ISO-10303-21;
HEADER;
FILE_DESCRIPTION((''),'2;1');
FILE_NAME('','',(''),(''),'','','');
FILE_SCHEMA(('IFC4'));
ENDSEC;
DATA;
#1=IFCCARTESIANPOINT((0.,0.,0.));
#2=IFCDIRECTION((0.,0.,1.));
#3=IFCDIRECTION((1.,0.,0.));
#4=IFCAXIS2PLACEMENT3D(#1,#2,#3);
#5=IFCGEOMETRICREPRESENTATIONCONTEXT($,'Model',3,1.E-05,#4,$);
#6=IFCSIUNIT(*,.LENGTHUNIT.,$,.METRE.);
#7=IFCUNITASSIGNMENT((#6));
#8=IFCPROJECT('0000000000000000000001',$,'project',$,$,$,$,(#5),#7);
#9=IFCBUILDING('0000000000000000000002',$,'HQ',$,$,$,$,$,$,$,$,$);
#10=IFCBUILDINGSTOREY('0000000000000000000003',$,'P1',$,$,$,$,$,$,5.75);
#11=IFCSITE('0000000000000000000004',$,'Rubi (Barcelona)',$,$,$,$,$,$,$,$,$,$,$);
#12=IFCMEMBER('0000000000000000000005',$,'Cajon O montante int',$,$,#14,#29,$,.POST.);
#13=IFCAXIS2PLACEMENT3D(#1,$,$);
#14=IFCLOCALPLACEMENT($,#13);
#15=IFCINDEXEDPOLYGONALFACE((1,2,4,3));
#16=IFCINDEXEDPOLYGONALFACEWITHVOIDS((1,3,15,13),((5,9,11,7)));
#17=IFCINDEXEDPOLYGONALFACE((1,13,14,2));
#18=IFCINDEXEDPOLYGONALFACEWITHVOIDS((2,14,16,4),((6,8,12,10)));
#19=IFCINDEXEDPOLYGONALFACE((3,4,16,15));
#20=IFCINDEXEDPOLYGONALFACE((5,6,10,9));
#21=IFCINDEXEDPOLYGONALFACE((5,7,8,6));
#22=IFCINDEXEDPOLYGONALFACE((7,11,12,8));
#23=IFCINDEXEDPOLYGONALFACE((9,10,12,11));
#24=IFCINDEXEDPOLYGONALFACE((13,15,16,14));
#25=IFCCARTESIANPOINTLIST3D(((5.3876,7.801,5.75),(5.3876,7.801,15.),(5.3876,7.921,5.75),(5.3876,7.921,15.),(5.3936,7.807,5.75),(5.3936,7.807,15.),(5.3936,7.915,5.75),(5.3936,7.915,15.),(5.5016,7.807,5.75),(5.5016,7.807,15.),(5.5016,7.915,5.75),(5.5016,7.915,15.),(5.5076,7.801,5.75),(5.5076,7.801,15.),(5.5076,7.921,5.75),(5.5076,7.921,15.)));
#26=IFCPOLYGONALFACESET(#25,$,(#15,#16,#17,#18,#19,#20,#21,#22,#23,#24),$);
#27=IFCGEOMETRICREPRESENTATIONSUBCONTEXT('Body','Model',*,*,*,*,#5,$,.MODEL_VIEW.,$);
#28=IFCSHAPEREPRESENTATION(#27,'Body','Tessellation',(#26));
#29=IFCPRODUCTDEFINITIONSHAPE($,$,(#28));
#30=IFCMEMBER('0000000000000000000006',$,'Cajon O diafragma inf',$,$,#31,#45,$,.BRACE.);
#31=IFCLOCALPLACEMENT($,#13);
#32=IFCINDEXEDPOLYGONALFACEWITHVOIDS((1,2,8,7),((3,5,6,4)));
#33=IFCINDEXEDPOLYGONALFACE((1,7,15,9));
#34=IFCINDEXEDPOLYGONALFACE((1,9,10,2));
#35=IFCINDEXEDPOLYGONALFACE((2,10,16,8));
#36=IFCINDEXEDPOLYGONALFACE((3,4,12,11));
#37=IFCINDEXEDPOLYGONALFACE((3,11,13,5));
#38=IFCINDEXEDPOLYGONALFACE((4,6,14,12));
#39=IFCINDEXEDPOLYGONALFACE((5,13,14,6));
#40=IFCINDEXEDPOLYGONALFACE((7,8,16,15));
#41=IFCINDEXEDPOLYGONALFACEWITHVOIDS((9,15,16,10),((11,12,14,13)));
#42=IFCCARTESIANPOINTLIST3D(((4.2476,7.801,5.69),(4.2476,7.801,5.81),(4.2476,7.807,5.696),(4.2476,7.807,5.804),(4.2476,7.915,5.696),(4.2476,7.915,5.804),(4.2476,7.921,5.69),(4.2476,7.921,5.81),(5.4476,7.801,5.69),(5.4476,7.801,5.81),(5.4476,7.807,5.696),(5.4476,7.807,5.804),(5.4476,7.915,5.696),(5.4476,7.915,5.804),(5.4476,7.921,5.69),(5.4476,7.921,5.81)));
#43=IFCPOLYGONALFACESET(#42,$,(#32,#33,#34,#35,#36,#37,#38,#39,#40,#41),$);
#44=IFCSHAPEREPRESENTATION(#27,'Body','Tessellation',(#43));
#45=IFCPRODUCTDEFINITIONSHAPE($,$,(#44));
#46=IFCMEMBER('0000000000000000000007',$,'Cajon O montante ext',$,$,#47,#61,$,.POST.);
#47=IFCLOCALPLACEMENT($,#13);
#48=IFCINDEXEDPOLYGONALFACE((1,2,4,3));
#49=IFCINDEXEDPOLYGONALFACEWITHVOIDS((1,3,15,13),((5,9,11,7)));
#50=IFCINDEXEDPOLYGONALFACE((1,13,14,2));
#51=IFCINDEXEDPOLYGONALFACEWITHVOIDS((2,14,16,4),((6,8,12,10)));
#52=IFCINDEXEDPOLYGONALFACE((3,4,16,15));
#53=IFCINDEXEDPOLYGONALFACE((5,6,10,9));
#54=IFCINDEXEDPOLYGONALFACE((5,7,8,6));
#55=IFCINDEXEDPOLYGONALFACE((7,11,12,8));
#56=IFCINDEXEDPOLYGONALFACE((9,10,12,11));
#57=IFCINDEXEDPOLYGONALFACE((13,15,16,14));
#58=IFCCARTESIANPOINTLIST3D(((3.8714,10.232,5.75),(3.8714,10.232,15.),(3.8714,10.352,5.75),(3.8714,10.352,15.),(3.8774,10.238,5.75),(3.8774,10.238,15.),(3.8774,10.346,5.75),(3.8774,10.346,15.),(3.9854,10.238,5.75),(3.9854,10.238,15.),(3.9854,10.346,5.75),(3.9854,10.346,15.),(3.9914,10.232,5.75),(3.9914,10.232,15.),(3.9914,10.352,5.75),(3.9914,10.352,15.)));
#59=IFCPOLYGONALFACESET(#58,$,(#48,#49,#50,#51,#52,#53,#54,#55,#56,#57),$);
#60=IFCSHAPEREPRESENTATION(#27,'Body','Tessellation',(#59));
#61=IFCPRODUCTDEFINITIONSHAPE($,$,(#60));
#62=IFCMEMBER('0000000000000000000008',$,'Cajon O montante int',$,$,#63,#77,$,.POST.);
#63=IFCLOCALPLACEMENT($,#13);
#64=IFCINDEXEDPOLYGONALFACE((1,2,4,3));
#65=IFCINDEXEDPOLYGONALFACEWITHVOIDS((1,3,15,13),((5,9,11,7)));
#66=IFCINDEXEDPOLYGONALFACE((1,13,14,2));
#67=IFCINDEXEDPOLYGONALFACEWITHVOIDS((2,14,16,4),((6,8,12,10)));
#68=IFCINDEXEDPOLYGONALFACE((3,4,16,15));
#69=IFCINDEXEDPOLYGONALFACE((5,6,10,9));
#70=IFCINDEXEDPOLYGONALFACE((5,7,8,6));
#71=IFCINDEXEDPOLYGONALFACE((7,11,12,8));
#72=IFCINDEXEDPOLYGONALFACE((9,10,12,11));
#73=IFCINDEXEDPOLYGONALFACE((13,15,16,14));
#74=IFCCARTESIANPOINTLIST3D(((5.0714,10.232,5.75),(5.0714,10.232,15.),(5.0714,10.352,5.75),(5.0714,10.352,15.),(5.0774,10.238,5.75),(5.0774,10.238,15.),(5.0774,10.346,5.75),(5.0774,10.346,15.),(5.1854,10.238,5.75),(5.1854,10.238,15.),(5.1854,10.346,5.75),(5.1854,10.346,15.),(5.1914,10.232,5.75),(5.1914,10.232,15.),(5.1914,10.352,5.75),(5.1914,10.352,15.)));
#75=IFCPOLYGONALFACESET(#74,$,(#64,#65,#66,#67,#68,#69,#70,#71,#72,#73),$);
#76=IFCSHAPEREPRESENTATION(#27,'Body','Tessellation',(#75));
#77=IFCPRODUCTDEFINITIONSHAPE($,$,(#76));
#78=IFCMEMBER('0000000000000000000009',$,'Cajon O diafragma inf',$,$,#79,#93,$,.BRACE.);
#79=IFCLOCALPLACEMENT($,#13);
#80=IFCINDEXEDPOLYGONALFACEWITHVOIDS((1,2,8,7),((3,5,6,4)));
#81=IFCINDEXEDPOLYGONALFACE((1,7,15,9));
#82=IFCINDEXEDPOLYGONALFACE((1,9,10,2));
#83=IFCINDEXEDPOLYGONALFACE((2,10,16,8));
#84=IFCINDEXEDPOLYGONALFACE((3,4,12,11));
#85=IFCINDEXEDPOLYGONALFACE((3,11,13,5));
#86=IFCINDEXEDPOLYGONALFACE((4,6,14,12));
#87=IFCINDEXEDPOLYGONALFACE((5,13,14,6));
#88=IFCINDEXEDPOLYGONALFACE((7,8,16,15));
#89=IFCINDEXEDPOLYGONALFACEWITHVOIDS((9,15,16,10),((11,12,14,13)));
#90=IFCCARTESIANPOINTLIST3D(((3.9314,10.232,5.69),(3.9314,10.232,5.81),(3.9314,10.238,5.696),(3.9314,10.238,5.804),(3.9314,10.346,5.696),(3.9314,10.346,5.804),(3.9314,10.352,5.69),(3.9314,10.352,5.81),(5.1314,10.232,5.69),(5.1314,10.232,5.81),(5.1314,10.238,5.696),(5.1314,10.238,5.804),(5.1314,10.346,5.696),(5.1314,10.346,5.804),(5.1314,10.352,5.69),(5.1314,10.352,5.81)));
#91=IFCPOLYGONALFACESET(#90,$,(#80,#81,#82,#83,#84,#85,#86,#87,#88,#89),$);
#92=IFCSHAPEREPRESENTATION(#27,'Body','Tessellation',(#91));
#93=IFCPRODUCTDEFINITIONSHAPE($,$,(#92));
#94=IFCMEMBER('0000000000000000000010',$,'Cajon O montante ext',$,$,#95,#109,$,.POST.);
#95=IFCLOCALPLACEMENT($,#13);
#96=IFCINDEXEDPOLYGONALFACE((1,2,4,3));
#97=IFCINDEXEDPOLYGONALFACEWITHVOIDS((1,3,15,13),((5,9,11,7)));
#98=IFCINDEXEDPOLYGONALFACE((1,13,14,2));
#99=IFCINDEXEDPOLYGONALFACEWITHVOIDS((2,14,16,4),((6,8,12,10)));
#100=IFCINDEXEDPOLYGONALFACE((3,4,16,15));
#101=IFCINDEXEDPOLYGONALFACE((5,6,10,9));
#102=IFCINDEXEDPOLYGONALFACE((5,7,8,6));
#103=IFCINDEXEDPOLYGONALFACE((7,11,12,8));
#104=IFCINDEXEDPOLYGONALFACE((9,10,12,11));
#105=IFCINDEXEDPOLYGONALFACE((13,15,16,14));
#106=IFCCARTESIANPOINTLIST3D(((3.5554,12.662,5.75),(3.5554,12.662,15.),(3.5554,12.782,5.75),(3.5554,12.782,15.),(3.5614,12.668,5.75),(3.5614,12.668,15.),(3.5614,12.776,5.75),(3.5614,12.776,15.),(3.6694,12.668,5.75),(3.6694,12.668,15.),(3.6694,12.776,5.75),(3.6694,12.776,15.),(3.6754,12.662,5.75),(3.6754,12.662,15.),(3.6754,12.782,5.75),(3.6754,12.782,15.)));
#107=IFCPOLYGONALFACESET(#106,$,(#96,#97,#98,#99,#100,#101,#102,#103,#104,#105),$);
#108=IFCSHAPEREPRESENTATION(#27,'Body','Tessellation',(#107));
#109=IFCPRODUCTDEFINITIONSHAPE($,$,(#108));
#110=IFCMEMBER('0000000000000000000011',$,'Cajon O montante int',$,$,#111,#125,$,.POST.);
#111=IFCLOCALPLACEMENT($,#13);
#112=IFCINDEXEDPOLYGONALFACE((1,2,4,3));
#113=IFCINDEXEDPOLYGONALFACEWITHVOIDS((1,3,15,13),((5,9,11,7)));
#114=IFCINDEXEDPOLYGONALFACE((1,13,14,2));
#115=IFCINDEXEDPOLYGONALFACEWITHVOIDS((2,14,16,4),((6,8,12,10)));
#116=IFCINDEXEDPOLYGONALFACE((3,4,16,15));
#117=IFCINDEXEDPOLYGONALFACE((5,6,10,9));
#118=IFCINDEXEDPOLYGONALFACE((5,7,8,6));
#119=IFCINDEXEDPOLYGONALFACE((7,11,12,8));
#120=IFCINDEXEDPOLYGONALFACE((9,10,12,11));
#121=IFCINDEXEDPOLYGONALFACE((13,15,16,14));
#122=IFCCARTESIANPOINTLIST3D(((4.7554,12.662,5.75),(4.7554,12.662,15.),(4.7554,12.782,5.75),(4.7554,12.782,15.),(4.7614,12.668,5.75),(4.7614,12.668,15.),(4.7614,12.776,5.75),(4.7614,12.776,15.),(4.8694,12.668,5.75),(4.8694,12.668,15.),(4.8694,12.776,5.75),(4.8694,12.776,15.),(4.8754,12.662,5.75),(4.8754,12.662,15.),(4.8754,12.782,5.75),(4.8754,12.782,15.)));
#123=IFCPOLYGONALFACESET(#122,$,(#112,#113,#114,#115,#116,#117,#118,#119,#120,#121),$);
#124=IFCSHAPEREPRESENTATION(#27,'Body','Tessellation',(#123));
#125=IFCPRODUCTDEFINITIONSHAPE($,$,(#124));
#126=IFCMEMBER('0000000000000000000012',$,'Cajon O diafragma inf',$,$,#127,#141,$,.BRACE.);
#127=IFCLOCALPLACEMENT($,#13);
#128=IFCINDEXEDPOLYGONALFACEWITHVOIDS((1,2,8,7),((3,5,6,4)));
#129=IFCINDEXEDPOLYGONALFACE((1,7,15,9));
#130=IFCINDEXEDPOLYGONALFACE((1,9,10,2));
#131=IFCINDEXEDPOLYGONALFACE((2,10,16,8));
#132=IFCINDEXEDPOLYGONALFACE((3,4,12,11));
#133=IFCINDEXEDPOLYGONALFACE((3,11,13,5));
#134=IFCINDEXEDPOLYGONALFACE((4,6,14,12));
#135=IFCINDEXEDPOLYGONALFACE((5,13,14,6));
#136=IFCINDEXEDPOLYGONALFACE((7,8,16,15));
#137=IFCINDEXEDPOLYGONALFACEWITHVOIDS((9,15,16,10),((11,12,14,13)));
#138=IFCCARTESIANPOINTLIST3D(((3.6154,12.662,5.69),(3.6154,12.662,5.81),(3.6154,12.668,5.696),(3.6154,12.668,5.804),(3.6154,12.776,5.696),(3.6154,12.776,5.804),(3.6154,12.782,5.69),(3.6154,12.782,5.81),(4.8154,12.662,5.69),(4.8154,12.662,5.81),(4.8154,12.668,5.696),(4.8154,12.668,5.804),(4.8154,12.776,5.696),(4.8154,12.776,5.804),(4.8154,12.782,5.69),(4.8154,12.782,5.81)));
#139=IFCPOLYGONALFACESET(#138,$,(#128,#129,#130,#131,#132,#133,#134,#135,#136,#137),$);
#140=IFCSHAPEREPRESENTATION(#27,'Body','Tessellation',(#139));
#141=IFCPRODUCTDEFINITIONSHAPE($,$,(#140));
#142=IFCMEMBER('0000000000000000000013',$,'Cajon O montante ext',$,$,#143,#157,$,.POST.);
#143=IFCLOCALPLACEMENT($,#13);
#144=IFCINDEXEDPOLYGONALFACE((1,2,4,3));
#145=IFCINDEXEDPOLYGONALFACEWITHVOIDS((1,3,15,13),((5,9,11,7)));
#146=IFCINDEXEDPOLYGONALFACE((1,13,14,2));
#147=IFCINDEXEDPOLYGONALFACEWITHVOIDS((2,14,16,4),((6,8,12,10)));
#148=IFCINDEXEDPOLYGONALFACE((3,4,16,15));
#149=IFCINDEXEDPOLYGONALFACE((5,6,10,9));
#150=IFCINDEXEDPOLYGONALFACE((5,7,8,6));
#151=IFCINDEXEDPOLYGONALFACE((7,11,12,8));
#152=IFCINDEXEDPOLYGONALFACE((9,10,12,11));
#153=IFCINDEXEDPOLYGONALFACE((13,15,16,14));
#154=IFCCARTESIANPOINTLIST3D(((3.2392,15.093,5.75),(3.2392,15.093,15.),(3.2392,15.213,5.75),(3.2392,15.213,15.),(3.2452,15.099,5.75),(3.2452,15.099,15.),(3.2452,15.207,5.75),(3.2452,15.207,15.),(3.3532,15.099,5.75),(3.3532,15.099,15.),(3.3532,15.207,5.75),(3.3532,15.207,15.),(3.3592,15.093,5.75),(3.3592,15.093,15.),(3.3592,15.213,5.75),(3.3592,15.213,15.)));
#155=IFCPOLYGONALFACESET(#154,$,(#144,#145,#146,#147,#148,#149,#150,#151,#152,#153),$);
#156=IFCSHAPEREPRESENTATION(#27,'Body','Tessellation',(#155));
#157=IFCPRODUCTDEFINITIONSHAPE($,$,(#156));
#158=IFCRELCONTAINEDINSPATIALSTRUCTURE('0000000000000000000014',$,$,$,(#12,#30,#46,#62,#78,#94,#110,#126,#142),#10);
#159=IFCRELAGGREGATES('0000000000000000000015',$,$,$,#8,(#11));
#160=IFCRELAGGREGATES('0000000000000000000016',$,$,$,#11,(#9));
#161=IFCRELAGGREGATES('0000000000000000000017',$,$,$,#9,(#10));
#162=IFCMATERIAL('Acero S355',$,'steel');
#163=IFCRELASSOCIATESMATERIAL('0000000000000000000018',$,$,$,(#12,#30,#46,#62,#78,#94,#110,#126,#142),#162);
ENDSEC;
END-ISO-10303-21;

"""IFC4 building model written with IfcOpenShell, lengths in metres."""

from ifc_helpers import new_model, si_unit, frame, origin_with_axes, place, context, subcontext, project, spatial, hollow_rectangle, extrude, material, element, save


model = new_model("IFC4")

# Units and contexts
model_context = context("Model", 3, precision=1e-05, world=origin_with_axes())
body_context = subcontext(model_context, "Body", "Model", "MODEL_VIEW")
ifc_project = project(units=[si_unit("LENGTHUNIT", "METRE")], contexts=[model_context])

# Site, building, storey
site = spatial("IfcSite", under=ifc_project, Name="Rubi (Barcelona)")
building = spatial("IfcBuilding", under=site, Name="HQ")
storey = spatial("IfcBuildingStorey", under=building, Name="P1", Elevation=5.75)

# Members
ifc_material = material(Name="Acero S355", Category="steel")
member_1_placement = place(None, origin_with_axes())
element("IfcMember", 1, at=member_1_placement, inside=storey, material=ifc_material, Name="Cajon O montante int", PredefinedType="POST", context=body_context, shape_type="SweptSolid", body=[
    extrude(hollow_rectangle(XDim=0.12, YDim=0.12, WallThickness=0.006), frame((5.4476, 7.861, 5.75), z_axis=(0.0, 0.0, 1.0), x_axis=(1.0, 0.0, 0.0)), (0.0, 0.0, 1.0), 9.25),
])
member_2_placement = place(None, origin_with_axes())
element("IfcMember", 2, at=member_2_placement, inside=storey, material=ifc_material, Name="Cajon O diafragma inf", PredefinedType="BRACE", context=body_context, shape_type="SweptSolid", body=[
    extrude(hollow_rectangle(XDim=0.12, YDim=0.12, WallThickness=0.006), frame((4.2476, 7.861, 5.75), z_axis=(1.0, 0.0, 0.0), x_axis=(0.0, 1.0, 0.0)), (0.0, 0.0, 1.0), 1.2),
])
member_3_placement = place(None, origin_with_axes())
element("IfcMember", 3, at=member_3_placement, inside=storey, material=ifc_material, Name="Cajon O montante ext", PredefinedType="POST", context=body_context, shape_type="SweptSolid", body=[
    extrude(hollow_rectangle(XDim=0.12, YDim=0.12, WallThickness=0.006), frame((3.9314, 10.292, 5.75), z_axis=(0.0, 0.0, 1.0), x_axis=(1.0, 0.0, 0.0)), (0.0, 0.0, 1.0), 9.25),
])
member_4_placement = place(None, origin_with_axes())
element("IfcMember", 4, at=member_4_placement, inside=storey, material=ifc_material, Name="Cajon O montante int", PredefinedType="POST", context=body_context, shape_type="SweptSolid", body=[
    extrude(hollow_rectangle(XDim=0.12, YDim=0.12, WallThickness=0.006), frame((5.1314, 10.292, 5.75), z_axis=(0.0, 0.0, 1.0), x_axis=(1.0, 0.0, 0.0)), (0.0, 0.0, 1.0), 9.25),
])
member_5_placement = place(None, origin_with_axes())
element("IfcMember", 5, at=member_5_placement, inside=storey, material=ifc_material, Name="Cajon O diafragma inf", PredefinedType="BRACE", context=body_context, shape_type="SweptSolid", body=[
    extrude(hollow_rectangle(XDim=0.12, YDim=0.12, WallThickness=0.006), frame((3.9314, 10.292, 5.75), z_axis=(1.0, 0.0, 0.0), x_axis=(0.0, 1.0, 0.0)), (0.0, 0.0, 1.0), 1.2),
])
member_6_placement = place(None, origin_with_axes())
element("IfcMember", 6, at=member_6_placement, inside=storey, material=ifc_material, Name="Cajon O montante ext", PredefinedType="POST", context=body_context, shape_type="SweptSolid", body=[
    extrude(hollow_rectangle(XDim=0.12, YDim=0.12, WallThickness=0.006), frame((3.6154, 12.722, 5.75), z_axis=(0.0, 0.0, 1.0), x_axis=(1.0, 0.0, 0.0)), (0.0, 0.0, 1.0), 9.25),
])
member_7_placement = place(None, origin_with_axes())
element("IfcMember", 7, at=member_7_placement, inside=storey, material=ifc_material, Name="Cajon O montante int", PredefinedType="POST", context=body_context, shape_type="SweptSolid", body=[
    extrude(hollow_rectangle(XDim=0.12, YDim=0.12, WallThickness=0.006), frame((4.8154, 12.722, 5.75), z_axis=(0.0, 0.0, 1.0), x_axis=(1.0, 0.0, 0.0)), (0.0, 0.0, 1.0), 9.25),
])
member_8_placement = place(None, origin_with_axes())
element("IfcMember", 8, at=member_8_placement, inside=storey, material=ifc_material, Name="Cajon O diafragma inf", PredefinedType="BRACE", context=body_context, shape_type="SweptSolid", body=[
    extrude(hollow_rectangle(XDim=0.12, YDim=0.12, WallThickness=0.006), frame((3.6154, 12.722, 5.75), z_axis=(1.0, 0.0, 0.0), x_axis=(0.0, 1.0, 0.0)), (0.0, 0.0, 1.0), 1.2),
])
member_9_placement = place(None, origin_with_axes())
element("IfcMember", 9, at=member_9_placement, inside=storey, material=ifc_material, Name="Cajon O montante ext", PredefinedType="POST", context=body_context, shape_type="SweptSolid", body=[
    extrude(hollow_rectangle(XDim=0.12, YDim=0.12, WallThickness=0.006), frame((3.2992, 15.153, 5.75), z_axis=(0.0, 0.0, 1.0), x_axis=(1.0, 0.0, 0.0)), (0.0, 0.0, 1.0), 9.25),
])

save(model, "model.ifc")
